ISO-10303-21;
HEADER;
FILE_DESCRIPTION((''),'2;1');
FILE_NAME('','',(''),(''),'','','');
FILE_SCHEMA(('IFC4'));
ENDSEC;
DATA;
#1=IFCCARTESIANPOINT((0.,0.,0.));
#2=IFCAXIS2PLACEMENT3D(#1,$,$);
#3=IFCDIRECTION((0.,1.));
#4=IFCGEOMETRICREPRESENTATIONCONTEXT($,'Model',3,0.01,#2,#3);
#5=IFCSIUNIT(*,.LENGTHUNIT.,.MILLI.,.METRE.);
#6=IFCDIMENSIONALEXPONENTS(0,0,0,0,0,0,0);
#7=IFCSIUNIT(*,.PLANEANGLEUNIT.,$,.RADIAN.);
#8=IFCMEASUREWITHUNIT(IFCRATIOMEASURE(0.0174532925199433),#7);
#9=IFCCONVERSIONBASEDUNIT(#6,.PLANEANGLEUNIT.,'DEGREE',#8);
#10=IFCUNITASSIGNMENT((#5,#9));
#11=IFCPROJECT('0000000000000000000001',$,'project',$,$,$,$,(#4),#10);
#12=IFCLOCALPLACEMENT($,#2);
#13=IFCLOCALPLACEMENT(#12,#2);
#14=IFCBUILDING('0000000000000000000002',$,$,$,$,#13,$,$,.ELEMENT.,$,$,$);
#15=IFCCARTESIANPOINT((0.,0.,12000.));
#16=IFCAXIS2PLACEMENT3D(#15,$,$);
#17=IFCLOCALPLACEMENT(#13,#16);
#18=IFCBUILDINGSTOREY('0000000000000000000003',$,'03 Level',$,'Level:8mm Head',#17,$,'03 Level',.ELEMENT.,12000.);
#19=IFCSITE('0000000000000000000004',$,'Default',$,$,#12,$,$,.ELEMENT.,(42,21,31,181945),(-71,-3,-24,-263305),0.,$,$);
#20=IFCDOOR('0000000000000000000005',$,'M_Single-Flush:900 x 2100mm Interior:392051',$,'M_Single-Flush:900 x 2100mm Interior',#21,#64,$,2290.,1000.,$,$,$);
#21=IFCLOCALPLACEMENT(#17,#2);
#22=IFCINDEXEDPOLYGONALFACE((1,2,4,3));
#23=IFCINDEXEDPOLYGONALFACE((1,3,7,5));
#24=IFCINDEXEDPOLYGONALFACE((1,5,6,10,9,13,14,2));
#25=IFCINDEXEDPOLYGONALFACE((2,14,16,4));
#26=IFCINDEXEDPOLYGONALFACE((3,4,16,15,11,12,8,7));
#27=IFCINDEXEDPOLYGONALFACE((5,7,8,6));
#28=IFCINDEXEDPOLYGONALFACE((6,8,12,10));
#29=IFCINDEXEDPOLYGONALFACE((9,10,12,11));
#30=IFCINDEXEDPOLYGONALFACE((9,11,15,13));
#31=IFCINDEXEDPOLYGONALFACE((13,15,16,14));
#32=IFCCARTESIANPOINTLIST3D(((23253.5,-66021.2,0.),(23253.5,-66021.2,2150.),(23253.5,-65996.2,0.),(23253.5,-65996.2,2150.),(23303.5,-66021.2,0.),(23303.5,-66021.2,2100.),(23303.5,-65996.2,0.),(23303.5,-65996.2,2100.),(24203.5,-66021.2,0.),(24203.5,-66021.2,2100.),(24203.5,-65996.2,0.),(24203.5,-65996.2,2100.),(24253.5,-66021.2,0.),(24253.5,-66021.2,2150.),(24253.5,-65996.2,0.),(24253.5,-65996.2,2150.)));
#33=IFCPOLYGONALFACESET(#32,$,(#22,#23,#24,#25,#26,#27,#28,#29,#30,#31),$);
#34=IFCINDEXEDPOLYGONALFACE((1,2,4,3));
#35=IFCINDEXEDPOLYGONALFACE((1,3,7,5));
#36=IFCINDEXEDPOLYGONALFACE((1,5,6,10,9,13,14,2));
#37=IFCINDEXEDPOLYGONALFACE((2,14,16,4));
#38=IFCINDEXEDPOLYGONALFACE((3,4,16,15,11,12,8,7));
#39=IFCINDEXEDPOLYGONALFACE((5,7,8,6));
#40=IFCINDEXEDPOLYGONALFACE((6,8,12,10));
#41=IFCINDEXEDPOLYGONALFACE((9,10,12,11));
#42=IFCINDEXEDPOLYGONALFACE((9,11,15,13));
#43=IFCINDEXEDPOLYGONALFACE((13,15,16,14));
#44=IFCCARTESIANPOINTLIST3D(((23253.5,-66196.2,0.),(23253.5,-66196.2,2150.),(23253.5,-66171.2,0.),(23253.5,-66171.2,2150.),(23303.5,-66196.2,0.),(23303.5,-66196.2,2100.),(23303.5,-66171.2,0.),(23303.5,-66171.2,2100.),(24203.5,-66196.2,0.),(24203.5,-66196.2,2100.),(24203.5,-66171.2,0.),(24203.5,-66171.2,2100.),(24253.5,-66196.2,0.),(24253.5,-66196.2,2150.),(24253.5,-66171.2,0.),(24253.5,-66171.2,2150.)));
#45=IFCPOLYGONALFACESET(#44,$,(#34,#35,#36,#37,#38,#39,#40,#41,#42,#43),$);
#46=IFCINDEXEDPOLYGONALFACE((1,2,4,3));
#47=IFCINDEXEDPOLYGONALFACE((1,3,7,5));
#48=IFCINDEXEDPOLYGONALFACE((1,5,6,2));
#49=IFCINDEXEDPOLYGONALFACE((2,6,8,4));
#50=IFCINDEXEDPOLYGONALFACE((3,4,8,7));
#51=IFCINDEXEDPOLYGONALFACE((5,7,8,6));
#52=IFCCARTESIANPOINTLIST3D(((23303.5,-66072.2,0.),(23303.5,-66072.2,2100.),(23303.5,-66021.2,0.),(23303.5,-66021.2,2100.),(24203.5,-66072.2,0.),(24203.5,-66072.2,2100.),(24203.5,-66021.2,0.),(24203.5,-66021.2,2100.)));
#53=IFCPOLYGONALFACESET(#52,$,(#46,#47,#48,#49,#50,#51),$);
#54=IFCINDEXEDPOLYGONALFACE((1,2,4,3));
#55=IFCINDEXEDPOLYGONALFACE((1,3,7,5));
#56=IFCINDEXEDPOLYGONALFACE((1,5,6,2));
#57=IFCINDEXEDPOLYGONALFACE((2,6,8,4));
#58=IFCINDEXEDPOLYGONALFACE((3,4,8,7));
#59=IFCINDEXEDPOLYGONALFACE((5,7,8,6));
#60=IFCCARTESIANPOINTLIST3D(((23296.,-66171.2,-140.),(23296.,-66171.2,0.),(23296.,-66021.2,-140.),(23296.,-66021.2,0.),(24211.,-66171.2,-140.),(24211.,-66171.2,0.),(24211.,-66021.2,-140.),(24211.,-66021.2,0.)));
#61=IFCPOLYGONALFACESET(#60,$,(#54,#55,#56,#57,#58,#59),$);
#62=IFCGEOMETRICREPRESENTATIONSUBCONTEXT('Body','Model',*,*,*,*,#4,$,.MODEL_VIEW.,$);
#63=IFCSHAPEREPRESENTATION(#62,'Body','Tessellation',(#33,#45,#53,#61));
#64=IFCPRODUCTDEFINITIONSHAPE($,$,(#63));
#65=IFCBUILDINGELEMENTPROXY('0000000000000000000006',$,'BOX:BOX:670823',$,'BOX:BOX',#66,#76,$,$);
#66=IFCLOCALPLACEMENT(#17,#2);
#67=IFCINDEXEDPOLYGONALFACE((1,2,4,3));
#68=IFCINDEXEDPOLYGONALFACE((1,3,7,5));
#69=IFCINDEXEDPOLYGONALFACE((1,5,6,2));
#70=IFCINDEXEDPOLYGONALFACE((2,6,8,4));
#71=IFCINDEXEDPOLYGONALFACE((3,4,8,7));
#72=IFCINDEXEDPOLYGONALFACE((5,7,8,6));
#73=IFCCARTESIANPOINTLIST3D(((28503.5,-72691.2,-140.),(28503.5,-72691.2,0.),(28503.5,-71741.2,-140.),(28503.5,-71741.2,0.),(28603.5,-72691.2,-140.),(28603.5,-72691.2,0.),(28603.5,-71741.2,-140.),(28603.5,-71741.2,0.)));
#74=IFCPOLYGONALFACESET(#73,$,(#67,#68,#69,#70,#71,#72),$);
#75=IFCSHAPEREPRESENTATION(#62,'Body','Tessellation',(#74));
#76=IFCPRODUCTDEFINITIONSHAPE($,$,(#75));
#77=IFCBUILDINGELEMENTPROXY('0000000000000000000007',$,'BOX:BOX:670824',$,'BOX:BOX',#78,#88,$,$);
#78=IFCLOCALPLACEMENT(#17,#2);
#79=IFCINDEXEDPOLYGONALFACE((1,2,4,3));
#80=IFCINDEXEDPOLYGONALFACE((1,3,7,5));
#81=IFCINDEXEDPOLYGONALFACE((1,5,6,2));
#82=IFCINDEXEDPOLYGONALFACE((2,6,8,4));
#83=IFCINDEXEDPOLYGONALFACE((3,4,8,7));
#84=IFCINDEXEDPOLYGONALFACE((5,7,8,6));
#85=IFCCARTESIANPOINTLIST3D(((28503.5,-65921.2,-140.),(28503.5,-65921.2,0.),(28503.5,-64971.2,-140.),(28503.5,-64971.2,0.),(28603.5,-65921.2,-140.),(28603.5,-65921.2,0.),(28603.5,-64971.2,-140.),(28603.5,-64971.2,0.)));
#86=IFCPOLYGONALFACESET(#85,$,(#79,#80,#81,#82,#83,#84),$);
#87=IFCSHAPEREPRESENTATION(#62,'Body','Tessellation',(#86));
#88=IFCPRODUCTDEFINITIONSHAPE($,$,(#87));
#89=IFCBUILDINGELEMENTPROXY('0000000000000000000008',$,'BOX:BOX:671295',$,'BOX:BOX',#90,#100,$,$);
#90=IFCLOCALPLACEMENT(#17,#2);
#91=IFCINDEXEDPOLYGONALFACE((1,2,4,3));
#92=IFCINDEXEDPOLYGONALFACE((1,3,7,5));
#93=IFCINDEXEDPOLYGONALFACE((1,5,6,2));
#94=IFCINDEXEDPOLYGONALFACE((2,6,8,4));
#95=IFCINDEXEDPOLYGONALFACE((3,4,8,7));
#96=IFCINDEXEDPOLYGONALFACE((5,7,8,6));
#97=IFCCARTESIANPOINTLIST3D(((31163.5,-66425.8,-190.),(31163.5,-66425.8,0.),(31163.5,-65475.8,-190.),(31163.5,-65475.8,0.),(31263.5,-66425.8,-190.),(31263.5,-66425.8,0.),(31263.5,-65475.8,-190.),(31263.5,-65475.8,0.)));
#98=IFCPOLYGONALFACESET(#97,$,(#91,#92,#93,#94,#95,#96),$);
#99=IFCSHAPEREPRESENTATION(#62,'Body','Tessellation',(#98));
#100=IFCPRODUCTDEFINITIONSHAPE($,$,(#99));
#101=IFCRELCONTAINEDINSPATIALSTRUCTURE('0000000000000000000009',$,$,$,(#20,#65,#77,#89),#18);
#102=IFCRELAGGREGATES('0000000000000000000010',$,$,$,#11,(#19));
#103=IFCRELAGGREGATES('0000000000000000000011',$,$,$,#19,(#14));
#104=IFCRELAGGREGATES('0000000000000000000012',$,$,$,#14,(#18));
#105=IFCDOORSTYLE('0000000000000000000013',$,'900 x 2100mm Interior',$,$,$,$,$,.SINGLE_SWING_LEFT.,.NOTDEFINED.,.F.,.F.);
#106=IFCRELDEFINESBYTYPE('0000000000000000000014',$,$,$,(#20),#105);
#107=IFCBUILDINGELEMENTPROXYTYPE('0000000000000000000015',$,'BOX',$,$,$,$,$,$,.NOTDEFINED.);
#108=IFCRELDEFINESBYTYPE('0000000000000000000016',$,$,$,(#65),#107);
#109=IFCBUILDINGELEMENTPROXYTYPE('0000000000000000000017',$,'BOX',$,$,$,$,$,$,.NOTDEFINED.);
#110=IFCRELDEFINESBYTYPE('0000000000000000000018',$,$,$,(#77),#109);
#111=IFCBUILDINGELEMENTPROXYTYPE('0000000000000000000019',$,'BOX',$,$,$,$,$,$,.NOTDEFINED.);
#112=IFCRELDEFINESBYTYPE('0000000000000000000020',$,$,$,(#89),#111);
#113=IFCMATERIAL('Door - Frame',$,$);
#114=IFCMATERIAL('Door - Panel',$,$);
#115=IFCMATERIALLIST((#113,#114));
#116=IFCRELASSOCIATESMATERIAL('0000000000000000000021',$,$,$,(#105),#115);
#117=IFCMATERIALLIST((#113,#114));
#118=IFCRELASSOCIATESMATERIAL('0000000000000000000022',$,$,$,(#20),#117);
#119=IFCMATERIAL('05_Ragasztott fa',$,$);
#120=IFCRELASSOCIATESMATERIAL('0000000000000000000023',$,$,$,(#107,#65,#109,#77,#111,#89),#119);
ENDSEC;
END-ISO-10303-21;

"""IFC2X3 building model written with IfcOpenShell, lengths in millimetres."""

from ifc_helpers import new_model, entity, si_unit, converted_unit, direction, frame, frame_2d, origin, origin_2d_with_axis, place, context, subcontext, project, spatial, polyline, rectangle, outline, extrude, source, transform, mapped, material, material_list, type_object, type_shapes, element, save


model = new_model("IFC2X3")

# Units and contexts
model_context = context("Model", 3, precision=0.01, world=origin(), true_north=direction((0.0, 1.0)))
body_context = subcontext(model_context, "Body", "Model", "MODEL_VIEW")
ifc_project = project(units=[si_unit("LENGTHUNIT", "METRE", prefix="MILLI"), converted_unit("PLANEANGLEUNIT", "DEGREE", entity("IfcRatioMeasure", 0.0174532925199433), si_unit("PLANEANGLEUNIT", "RADIAN"), dimensions=[0, 0, 0, 0, 0, 0, 0])], contexts=[model_context])

# Site, building, storey
site_placement = place(None, origin())
site = spatial("IfcSite", under=ifc_project, at=site_placement, Name="Default", CompositionType="ELEMENT", RefLatitude=(42, 21, 31, 181945), RefLongitude=(-71, -3, -24, -263305), RefElevation=0.0)
building_placement = place(site_placement, origin())
building = spatial("IfcBuilding", under=site, at=building_placement, CompositionType="ELEMENT")
storey_placement = place(building_placement, frame((0.0, 0.0, 12000.0)))
storey = spatial("IfcBuildingStorey", under=building, at=storey_placement, Name="03 Level", ObjectType="Level:8mm Head", LongName="03 Level", CompositionType="ELEMENT", Elevation=12000.0)

# Shared definitions
ifc_material_1 = material(Name="Door - Frame")
ifc_material_2 = material(Name="Door - Panel")

# Door
ifc_material_list_1 = material_list([ifc_material_1, ifc_material_2])
ifc_material_list_2 = material_list([ifc_material_1, ifc_material_2])
door_style_1 = type_object("IfcDoorStyle", Name="900 x 2100mm Interior", ConstructionType="NOTDEFINED", OperationType="SINGLE_SWING_LEFT", ParameterTakesPrecedence=False, Sizeable=False, material=ifc_material_list_2)
shared_shape_1 = source(origin(), body_context, "Body", "SweptSolid", [
    extrude(outline(polyline([(-500.0, -1087.5), (500.0, -1087.5), (500.0, 1062.5), (450.0, 1062.5), (450.0, -1037.5), (-450.0, -1037.5), (-450.0, 1062.5), (-500.0, 1062.5), (-500.0, -1087.5)])), frame((450.0, 175.0, 1202.5), z_axis=(0.0, -1.0, 0.0), x_axis=(-1.0, 0.0, 0.0)), (0.0, 0.0, 1.0), 25.0),
    extrude(outline(polyline([(-1087.5, -500.0), (1062.5, -500.0), (1062.5, -450.0), (-1037.5, -450.0), (-1037.5, 450.0), (1062.5, 450.0), (1062.5, 500.0), (-1087.5, 500.0), (-1087.5, -500.0)])), frame((450.0, 0.0, 1202.5), z_axis=(0.0, -1.0, 0.0), x_axis=(0.0, 0.0, -1.0)), (0.0, 0.0, 1.0), 25.0),
    extrude(rectangle(XDim=900.0, YDim=51.0, at=frame_2d((0.0, 0.0), x_axis=(1.0, 0.0))), frame((450.0, 124.5, 140.0)), (0.0, 0.0, 1.0), 2100.0),
    extrude(rectangle(XDim=150.0, YDim=915.0, at=origin_2d_with_axis()), frame((450.0, 75.0, 0.0), z_axis=(0.0, 0.0, 1.0), x_axis=(0.0, -1.0, 0.0)), (0.0, 0.0, 1.0), 140.0),
])
type_shapes(door_style_1, [shared_shape_1])
door_1_placement = place(storey_placement, frame((23303.5, -66171.2, -140.0)))
element("IfcDoor", 1, at=door_1_placement, inside=storey, type_object=door_style_1, material=ifc_material_list_1, Name="M_Single-Flush:900 x 2100mm Interior:392051", ObjectType="M_Single-Flush:900 x 2100mm Interior", OverallHeight=2290.0, OverallWidth=1000.0, context=body_context, shape_type="MappedRepresentation", body=[
    mapped(shared_shape_1, transform((0.0, 0.0, 0.0), scale=1.0)),
])

# Building element proxies
ifc_material_3 = material(Name="05_Ragasztott fa")
building_element_proxy_type_1 = type_object("IfcBuildingElementProxyType", Name="BOX", PredefinedType="NOTDEFINED", material=ifc_material_3)
shared_shape_2 = source(origin(), body_context, "Body", "SweptSolid", [
    extrude(rectangle(XDim=100.0, YDim=950.0, at=frame_2d((0.0, 0.0), x_axis=(1.0, 0.0))), frame((50.0, 475.0, 0.0), z_axis=(0.0, 0.0, 1.0), x_axis=(-1.0, 0.0, 0.0)), (0.0, 0.0, 1.0), 140.0),
])
type_shapes(building_element_proxy_type_1, [shared_shape_2])
proxy_1_placement = place(storey_placement, frame((28503.5, -72691.2, -140.0)))
element("IfcBuildingElementProxy", 2, at=proxy_1_placement, inside=storey, type_object=building_element_proxy_type_1, material=ifc_material_3, Name="BOX:BOX:670823", ObjectType="BOX:BOX", context=body_context, shape_type="MappedRepresentation", body=[
    mapped(shared_shape_2, transform((0.0, 0.0, 0.0), scale=1.0)),
])
building_element_proxy_type_2 = type_object("IfcBuildingElementProxyType", Name="BOX", PredefinedType="NOTDEFINED", material=ifc_material_3)
shared_shape_3 = source(origin(), body_context, "Body", "SweptSolid", [
    extrude(rectangle(XDim=100.0, YDim=950.0, at=frame_2d((0.0, 0.0), x_axis=(1.0, 0.0))), frame((50.0, 475.0, 0.0), z_axis=(0.0, 0.0, 1.0), x_axis=(-1.0, 0.0, 0.0)), (0.0, 0.0, 1.0), 140.0),
])
type_shapes(building_element_proxy_type_2, [shared_shape_3])
proxy_2_placement = place(storey_placement, frame((28503.5, -65921.2, -140.0)))
element("IfcBuildingElementProxy", 3, at=proxy_2_placement, inside=storey, type_object=building_element_proxy_type_2, material=ifc_material_3, Name="BOX:BOX:670824", ObjectType="BOX:BOX", context=body_context, shape_type="MappedRepresentation", body=[
    mapped(shared_shape_3, transform((0.0, 0.0, 0.0), scale=1.0)),
])
building_element_proxy_type_3 = type_object("IfcBuildingElementProxyType", Name="BOX", PredefinedType="NOTDEFINED", material=ifc_material_3)
shared_shape_4 = source(origin(), body_context, "Body", "SweptSolid", [
    extrude(rectangle(XDim=100.0, YDim=950.0, at=frame_2d((0.0, 0.0), x_axis=(1.0, 0.0))), frame((50.0, 475.0, 0.0), z_axis=(0.0, 0.0, 1.0), x_axis=(-1.0, 0.0, 0.0)), (0.0, 0.0, 1.0), 190.0),
])
type_shapes(building_element_proxy_type_3, [shared_shape_4])
proxy_3_placement = place(storey_placement, frame((31163.5, -66425.8, -190.0)))
element("IfcBuildingElementProxy", 4, at=proxy_3_placement, inside=storey, type_object=building_element_proxy_type_3, material=ifc_material_3, Name="BOX:BOX:671295", ObjectType="BOX:BOX", context=body_context, shape_type="MappedRepresentation", body=[
    mapped(shared_shape_4, transform((0.0, 0.0, 0.0), scale=1.0)),
])

save(model, "model.ifc")
